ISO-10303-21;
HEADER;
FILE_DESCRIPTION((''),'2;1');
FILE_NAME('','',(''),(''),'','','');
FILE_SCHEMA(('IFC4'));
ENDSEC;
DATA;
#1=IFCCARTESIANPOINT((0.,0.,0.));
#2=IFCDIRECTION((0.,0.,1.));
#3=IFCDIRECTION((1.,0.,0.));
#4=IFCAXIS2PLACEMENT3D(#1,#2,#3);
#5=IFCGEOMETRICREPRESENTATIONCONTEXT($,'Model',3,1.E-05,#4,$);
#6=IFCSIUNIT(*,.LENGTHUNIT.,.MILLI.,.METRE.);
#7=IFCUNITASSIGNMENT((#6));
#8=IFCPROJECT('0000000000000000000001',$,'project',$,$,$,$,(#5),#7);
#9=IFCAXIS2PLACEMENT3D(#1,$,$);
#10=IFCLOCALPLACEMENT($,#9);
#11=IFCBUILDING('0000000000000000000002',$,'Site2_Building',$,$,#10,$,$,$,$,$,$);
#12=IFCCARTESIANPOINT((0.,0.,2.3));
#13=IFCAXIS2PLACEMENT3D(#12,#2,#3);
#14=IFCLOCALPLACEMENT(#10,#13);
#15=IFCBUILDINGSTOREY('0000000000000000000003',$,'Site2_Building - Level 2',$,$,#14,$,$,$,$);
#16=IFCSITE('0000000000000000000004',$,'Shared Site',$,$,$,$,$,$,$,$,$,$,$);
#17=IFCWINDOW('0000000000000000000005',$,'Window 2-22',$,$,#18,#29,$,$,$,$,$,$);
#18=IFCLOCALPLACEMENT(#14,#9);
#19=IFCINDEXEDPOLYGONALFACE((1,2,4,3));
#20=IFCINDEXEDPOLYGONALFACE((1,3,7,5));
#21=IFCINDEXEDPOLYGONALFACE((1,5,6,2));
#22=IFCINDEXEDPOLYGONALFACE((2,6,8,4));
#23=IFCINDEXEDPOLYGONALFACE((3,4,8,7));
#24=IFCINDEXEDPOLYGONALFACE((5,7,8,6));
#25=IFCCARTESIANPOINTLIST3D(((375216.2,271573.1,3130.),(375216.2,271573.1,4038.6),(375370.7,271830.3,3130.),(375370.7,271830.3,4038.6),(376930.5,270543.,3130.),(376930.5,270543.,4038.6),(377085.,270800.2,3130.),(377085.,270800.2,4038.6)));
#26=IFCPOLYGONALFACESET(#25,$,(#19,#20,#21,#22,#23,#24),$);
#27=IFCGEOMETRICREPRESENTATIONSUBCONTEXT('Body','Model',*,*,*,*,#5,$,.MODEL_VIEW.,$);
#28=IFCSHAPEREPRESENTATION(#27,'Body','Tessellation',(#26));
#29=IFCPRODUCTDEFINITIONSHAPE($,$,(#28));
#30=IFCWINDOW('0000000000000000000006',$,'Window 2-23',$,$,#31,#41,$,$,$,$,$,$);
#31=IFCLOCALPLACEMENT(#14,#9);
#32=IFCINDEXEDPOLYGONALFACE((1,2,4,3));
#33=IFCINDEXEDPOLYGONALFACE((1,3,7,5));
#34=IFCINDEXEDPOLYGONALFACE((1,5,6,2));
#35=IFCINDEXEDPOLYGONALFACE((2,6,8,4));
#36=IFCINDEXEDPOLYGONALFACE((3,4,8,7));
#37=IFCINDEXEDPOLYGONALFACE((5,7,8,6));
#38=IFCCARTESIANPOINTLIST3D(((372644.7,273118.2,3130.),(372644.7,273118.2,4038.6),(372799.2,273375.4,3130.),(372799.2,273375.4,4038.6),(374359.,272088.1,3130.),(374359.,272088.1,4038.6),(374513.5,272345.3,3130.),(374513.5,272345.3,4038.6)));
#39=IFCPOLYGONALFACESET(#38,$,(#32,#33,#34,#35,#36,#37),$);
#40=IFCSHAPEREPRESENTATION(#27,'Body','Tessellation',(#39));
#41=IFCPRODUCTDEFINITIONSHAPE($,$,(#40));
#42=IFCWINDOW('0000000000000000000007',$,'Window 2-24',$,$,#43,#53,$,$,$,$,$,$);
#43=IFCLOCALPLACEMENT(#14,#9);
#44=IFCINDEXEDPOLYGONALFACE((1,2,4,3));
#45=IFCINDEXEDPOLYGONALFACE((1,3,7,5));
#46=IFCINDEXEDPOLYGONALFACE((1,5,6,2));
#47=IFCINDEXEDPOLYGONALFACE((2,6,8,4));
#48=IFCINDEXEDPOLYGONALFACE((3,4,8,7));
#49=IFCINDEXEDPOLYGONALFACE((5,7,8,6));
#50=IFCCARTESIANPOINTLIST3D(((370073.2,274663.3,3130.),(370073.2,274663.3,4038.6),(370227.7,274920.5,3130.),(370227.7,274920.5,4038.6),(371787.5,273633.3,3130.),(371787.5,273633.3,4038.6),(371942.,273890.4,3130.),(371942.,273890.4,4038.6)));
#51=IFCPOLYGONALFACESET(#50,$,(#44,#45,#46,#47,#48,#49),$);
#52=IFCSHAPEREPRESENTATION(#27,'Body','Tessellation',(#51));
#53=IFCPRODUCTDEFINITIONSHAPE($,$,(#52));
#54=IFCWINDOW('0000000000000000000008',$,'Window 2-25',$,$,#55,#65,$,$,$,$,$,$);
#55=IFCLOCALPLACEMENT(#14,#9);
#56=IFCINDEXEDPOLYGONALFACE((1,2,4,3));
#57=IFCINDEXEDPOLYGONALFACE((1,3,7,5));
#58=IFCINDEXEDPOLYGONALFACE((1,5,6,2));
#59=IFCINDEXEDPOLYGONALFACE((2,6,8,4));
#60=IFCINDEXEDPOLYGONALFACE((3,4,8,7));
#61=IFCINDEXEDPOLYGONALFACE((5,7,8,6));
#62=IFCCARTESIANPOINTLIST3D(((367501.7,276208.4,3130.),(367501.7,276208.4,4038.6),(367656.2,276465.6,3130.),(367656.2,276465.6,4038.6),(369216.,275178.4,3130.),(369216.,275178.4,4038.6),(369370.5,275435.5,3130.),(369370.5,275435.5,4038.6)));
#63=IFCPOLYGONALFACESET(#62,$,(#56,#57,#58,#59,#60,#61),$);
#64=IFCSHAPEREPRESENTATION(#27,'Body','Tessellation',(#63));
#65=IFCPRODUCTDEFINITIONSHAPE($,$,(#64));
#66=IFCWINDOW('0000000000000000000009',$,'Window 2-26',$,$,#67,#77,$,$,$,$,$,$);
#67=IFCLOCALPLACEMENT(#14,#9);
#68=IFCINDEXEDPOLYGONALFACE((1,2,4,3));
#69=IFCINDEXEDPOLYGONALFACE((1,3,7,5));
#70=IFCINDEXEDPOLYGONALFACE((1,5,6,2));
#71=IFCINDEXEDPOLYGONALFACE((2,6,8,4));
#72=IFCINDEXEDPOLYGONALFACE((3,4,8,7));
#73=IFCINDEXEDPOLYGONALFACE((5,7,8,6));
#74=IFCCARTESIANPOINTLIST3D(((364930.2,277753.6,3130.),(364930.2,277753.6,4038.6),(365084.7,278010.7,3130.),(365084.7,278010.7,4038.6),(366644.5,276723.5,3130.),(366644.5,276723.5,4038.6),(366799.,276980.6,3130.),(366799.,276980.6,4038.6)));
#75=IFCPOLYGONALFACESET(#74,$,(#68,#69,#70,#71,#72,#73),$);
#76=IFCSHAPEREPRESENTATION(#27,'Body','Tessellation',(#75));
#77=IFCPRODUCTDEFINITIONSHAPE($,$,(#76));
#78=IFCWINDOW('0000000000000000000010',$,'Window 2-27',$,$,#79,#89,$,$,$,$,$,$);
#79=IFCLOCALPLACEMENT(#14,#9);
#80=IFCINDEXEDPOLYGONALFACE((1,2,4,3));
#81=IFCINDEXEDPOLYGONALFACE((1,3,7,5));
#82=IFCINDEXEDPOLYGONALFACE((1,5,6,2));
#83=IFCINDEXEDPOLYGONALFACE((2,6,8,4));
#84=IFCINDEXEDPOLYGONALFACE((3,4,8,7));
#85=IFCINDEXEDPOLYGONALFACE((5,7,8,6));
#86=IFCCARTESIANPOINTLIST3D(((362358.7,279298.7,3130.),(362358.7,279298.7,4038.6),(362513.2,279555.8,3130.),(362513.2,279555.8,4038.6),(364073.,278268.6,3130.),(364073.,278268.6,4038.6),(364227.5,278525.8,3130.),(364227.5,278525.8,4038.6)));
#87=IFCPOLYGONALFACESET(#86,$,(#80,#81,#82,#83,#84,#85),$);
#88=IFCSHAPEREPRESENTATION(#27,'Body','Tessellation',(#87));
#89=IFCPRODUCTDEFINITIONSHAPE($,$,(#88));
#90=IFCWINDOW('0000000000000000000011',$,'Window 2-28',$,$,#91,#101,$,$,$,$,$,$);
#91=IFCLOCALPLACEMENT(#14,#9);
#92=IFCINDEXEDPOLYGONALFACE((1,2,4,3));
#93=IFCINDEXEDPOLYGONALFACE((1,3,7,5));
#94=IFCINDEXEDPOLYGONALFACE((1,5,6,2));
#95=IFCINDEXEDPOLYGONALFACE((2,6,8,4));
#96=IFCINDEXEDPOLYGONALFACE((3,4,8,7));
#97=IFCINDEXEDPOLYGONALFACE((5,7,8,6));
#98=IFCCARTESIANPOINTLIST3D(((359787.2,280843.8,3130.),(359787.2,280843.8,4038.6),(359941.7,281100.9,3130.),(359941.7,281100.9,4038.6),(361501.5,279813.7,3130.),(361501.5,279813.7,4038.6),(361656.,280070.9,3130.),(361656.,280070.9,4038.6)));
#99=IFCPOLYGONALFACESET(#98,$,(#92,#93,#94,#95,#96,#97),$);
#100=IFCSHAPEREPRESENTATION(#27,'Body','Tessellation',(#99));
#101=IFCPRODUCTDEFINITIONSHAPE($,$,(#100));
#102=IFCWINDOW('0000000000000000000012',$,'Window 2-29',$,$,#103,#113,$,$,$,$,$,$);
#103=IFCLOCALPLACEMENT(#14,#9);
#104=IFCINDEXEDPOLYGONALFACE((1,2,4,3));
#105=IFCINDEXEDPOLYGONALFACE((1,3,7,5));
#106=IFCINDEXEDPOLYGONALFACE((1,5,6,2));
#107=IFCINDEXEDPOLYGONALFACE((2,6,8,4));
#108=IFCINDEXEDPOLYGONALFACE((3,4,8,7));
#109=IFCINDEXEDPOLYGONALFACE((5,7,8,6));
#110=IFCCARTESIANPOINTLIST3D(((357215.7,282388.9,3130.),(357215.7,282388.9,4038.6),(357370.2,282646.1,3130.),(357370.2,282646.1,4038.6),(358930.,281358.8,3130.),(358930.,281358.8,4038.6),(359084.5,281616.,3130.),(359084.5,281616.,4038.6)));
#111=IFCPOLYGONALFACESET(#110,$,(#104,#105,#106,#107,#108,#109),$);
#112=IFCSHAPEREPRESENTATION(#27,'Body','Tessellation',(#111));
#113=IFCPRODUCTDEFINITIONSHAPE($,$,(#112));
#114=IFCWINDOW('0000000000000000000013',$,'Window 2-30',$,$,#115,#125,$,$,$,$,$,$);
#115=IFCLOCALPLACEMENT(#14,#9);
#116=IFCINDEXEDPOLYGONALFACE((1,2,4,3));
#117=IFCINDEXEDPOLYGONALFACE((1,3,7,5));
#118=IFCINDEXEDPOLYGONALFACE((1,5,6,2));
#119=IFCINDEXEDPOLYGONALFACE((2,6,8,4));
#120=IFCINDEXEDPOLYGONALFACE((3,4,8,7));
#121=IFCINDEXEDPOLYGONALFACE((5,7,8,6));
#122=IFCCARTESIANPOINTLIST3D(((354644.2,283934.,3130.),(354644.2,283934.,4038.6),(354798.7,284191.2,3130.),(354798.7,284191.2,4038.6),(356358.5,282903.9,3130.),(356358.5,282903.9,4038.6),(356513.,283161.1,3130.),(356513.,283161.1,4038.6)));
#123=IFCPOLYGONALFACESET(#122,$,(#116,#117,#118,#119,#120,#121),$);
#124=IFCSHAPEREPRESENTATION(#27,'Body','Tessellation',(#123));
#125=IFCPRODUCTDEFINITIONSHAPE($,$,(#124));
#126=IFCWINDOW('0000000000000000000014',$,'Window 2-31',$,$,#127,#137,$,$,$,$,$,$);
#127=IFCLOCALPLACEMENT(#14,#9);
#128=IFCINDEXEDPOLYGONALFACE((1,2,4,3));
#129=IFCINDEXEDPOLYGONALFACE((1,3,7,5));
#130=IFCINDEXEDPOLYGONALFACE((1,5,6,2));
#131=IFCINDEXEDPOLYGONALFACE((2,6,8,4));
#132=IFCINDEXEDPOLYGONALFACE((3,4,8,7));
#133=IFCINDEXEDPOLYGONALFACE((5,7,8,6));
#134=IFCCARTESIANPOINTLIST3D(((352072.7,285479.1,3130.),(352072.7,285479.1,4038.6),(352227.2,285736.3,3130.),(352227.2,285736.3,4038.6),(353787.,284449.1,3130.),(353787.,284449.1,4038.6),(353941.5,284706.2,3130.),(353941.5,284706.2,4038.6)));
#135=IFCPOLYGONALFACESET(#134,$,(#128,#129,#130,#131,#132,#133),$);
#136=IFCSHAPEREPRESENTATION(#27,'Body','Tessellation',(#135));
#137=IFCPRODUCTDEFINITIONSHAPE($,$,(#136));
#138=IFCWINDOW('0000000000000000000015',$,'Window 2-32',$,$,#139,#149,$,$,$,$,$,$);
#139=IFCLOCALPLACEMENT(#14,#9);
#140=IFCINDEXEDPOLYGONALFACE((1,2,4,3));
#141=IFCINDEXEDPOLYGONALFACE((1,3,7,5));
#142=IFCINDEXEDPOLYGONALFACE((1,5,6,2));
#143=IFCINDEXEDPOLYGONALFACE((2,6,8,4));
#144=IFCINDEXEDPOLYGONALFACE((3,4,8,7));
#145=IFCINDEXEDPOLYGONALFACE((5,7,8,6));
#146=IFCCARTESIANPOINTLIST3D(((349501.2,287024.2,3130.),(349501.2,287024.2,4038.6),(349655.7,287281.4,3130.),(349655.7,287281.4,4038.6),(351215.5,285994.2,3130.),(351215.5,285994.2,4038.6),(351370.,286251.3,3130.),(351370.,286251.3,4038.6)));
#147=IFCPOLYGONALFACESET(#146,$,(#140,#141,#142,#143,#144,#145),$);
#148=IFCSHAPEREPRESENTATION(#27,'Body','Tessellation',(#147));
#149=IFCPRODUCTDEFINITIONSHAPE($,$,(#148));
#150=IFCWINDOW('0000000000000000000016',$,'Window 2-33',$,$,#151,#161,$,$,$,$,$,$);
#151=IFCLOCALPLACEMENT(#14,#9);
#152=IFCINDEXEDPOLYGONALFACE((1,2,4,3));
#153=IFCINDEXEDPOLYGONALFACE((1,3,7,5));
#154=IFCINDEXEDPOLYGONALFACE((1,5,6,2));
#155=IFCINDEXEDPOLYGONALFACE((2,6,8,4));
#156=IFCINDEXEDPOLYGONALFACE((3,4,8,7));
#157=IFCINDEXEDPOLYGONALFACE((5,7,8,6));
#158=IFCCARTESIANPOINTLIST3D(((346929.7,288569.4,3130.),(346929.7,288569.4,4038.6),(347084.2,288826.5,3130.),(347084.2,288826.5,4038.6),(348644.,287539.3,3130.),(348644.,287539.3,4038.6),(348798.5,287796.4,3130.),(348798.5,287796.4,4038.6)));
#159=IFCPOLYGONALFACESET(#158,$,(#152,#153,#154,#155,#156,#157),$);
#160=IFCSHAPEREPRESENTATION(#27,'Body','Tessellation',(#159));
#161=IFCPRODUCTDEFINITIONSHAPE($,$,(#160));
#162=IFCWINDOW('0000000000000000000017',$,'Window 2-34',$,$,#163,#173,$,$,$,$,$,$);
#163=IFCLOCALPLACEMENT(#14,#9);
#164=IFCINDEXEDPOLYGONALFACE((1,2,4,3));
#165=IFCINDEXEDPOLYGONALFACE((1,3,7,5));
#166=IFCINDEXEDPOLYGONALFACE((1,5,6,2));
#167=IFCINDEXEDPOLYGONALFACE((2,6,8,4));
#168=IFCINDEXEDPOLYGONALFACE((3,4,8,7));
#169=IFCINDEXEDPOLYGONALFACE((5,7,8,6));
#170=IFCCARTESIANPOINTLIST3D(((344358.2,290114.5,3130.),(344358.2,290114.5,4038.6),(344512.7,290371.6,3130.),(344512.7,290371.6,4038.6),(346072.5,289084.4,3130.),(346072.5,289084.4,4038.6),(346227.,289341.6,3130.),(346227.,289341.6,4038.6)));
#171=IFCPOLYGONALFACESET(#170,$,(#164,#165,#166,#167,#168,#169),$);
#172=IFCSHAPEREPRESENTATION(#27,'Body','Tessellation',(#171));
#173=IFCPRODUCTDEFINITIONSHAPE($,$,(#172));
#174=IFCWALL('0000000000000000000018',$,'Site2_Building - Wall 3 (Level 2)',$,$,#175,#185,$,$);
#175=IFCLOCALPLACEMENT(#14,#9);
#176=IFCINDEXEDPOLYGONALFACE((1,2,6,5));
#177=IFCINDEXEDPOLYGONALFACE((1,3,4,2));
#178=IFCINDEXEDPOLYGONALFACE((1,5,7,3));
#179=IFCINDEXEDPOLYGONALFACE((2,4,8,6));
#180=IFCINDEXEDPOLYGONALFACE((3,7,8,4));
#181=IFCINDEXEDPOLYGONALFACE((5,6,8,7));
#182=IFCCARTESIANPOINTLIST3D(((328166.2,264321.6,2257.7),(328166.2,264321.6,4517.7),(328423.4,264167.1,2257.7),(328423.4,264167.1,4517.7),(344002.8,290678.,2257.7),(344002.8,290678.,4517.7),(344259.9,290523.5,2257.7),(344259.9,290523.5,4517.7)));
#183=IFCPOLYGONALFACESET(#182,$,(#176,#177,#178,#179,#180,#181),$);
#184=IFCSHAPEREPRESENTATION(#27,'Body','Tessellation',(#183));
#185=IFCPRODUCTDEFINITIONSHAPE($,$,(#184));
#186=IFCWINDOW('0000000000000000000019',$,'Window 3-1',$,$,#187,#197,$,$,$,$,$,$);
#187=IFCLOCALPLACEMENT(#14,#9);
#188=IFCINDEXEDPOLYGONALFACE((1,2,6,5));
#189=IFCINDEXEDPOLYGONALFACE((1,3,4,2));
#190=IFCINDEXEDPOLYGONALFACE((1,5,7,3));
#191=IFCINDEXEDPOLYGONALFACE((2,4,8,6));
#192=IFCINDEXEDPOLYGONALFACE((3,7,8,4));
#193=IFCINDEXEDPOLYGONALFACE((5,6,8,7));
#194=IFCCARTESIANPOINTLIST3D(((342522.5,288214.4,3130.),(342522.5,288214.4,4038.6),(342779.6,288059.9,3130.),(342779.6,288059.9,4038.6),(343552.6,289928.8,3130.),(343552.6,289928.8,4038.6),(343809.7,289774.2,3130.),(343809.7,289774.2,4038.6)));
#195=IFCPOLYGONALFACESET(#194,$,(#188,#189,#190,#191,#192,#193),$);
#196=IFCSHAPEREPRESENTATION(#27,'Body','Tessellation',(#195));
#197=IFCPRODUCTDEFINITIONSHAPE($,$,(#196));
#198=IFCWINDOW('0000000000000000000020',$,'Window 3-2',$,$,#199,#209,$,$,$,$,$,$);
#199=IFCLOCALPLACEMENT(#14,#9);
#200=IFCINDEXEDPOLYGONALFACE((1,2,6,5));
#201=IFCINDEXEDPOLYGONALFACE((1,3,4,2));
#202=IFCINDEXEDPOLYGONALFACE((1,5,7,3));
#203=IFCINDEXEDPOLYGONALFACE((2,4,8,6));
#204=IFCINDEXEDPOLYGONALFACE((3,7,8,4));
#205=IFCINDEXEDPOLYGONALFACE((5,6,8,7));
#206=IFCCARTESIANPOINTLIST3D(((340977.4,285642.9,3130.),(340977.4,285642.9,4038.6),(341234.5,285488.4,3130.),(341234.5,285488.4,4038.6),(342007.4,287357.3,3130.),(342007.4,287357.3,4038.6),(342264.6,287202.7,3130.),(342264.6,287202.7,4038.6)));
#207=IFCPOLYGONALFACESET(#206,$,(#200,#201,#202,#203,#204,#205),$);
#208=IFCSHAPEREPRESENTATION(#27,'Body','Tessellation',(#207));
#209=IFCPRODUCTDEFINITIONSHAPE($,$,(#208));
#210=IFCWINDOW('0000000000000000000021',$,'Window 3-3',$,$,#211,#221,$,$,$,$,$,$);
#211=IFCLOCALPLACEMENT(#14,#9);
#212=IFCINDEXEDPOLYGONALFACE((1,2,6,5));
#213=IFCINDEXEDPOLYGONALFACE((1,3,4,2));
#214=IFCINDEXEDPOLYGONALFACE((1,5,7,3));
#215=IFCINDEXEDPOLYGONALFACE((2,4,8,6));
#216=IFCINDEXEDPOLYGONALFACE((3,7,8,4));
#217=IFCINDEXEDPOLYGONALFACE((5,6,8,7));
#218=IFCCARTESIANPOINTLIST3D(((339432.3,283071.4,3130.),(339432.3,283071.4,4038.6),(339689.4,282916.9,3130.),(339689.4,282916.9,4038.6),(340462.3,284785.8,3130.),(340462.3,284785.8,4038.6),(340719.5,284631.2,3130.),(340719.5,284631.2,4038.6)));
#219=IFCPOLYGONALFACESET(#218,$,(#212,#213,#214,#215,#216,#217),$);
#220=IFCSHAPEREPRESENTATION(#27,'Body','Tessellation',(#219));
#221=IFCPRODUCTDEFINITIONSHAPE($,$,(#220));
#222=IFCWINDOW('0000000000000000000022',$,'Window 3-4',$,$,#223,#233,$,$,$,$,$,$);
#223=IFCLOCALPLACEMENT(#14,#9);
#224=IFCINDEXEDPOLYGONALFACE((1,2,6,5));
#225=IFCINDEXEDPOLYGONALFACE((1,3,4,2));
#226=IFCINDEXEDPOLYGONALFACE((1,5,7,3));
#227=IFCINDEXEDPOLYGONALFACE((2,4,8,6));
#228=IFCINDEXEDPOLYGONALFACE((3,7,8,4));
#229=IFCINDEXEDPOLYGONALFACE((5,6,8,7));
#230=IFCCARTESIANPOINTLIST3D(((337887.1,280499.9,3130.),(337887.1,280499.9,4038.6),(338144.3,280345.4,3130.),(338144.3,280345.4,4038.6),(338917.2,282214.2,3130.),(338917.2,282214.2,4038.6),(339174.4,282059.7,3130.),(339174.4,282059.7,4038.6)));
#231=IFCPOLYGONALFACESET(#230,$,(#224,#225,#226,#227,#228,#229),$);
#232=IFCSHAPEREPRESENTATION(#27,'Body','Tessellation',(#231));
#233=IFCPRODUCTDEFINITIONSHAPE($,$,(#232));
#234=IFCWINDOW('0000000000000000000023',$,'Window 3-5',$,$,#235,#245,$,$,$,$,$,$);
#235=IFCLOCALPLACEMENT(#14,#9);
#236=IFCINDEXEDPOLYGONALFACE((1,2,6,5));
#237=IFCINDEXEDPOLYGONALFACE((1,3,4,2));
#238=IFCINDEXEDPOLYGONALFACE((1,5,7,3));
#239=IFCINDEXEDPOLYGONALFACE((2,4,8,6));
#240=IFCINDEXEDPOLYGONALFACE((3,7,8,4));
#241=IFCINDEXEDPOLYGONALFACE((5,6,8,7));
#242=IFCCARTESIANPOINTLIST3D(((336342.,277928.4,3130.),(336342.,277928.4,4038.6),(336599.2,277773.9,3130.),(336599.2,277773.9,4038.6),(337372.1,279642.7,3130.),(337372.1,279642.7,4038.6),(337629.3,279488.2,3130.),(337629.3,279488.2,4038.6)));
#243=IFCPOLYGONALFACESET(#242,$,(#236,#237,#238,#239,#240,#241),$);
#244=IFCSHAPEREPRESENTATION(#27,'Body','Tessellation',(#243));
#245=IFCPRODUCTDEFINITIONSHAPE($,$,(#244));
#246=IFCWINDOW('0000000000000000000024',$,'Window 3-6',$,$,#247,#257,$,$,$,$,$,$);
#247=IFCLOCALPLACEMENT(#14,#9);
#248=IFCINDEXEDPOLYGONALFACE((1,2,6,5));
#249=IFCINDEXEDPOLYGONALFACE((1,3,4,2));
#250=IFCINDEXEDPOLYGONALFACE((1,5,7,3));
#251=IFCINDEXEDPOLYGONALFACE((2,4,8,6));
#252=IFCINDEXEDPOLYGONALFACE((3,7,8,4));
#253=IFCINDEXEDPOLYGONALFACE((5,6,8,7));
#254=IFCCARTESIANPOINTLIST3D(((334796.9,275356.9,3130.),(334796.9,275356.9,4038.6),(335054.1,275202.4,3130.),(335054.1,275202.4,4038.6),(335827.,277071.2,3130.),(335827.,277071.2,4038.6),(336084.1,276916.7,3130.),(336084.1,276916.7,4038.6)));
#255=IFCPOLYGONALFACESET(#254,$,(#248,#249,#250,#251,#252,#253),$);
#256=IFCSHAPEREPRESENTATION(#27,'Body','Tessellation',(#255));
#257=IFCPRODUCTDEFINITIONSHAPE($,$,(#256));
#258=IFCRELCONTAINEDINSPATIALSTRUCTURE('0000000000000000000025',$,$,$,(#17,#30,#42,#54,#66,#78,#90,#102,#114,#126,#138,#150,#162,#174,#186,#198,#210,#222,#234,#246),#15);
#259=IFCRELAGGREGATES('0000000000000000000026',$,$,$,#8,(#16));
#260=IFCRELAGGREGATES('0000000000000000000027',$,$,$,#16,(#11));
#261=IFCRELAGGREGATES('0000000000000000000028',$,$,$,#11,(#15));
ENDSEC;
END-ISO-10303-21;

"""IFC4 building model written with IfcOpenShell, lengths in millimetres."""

from ifc_helpers import new_model, si_unit, frame, origin, origin_with_axes, place, context, subcontext, project, spatial, indexed_curve, outline, extrude, element, save


model = new_model("IFC4")

# Units and contexts
model_context = context("Model", 3, precision=1e-05, world=origin_with_axes())
body_context = subcontext(model_context, "Body", "Model", "MODEL_VIEW")
ifc_project = project(units=[si_unit("LENGTHUNIT", "METRE", prefix="MILLI")], contexts=[model_context])

# Site, building, storey
site = spatial("IfcSite", under=ifc_project, Name="Shared Site")
building_placement = place(None, origin())
building = spatial("IfcBuilding", under=site, at=building_placement, Name="Site2_Building")
storey_placement = place(building_placement, frame((0.0, 0.0, 2.3), z_axis=(0.0, 0.0, 1.0), x_axis=(1.0, 0.0, 0.0)))
storey = spatial("IfcBuildingStorey", under=building, at=storey_placement, Name="Site2_Building - Level 2")

# Windows
for number, where, z_axis, x_axis, name in (
    (1, (377085.0, 270800.2, 3130.0), (0.0, 0.0, 1.0), (-0.857167, 0.515038, 0.0), "Window 2-22"),
    (2, (374513.5, 272345.3, 3130.0), (0.0, 0.0, 1.0), (-0.857167, 0.515038, 0.0), "Window 2-23"),
    (3, (371942.0, 273890.4, 3130.0), (0.0, 0.0, 1.0), (-0.857167, 0.515038, 0.0), "Window 2-24"),
    (4, (369370.5, 275435.5, 3130.0), (0.0, 0.0, 1.0), (-0.857167, 0.515038, 0.0), "Window 2-25"),
    (5, (366799.0, 276980.6, 3130.0), (0.0, 0.0, 1.0), (-0.857167, 0.515038, 0.0), "Window 2-26"),
    (6, (364227.5, 278525.8, 3130.0), (0.0, 0.0, 1.0), (-0.857167, 0.515038, 0.0), "Window 2-27"),
    (7, (361656.0, 280070.9, 3130.0), (0.0, 0.0, 1.0), (-0.857167, 0.515038, 0.0), "Window 2-28"),
    (8, (359084.5, 281616.0, 3130.0), (0.0, 0.0, 1.0), (-0.857167, 0.515038, 0.0), "Window 2-29"),
    (9, (356513.0, 283161.1, 3130.0), (0.0, 0.0, 1.0), (-0.857167, 0.515038, 0.0), "Window 2-30"),
    (10, (353941.5, 284706.2, 3130.0), (0.0, 0.0, 1.0), (-0.857167, 0.515038, 0.0), "Window 2-31"),
    (11, (351370.0, 286251.3, 3130.0), (0.0, 0.0, 1.0), (-0.857167, 0.515038, 0.0), "Window 2-32"),
    (12, (348798.5, 287796.4, 3130.0), (0.0, 0.0, 1.0), (-0.857167, 0.515038, 0.0), "Window 2-33"),
    (13, (346227.0, 289341.6, 3130.0), (0.0, 0.0, 1.0), (-0.857167, 0.515038, 0.0), "Window 2-34"),
):
    element("IfcWindow", number, at=place(storey_placement, frame(where, z_axis=z_axis, x_axis=x_axis)), inside=storey, Name=name, context=body_context, shape_type="SweptSolid", body=[
        extrude(outline(indexed_curve([(0.0, 0.0), (0.0, 300.0), (2000.0, 300.0), (2000.0, 0.0), (0.0, 0.0)], self_intersect=False)), origin_with_axes(), (0.0, 0.0, 1.0), 908.6),
    ])

# Wall
wall_placement = place(storey_placement, frame((344002.8, 290678.0, 2257.7), z_axis=(0.0, 0.0, 1.0), x_axis=(-0.515038, -0.857167, 0.0)))
element("IfcWall", 14, at=wall_placement, inside=storey, Name="Site2_Building - Wall 3 (Level 2)", context=body_context, shape_type="SweptSolid", body=[
    extrude(outline(indexed_curve([(0.0, 0.0), (0.0, 300.0), (30748.2, 300.0), (30748.2, 0.0), (0.0, 0.0)], self_intersect=False)), origin_with_axes(), (0.0, 0.0, 1.0), 2260.0),
])

# Windows
for number, where, z_axis, x_axis, name in (
    (15, (343552.6, 289928.8, 3130.0), (0.0, 0.0, 1.0), (-0.515038, -0.857167, 0.0), "Window 3-1"),
    (16, (342007.4, 287357.3, 3130.0), (0.0, 0.0, 1.0), (-0.515038, -0.857167, 0.0), "Window 3-2"),
    (17, (340462.3, 284785.8, 3130.0), (0.0, 0.0, 1.0), (-0.515038, -0.857167, 0.0), "Window 3-3"),
    (18, (338917.2, 282214.2, 3130.0), (0.0, 0.0, 1.0), (-0.515038, -0.857167, 0.0), "Window 3-4"),
    (19, (337372.1, 279642.7, 3130.0), (0.0, 0.0, 1.0), (-0.515038, -0.857167, 0.0), "Window 3-5"),
    (20, (335827.0, 277071.2, 3130.0), (0.0, 0.0, 1.0), (-0.515038, -0.857167, 0.0), "Window 3-6"),
):
    element("IfcWindow", number, at=place(storey_placement, frame(where, z_axis=z_axis, x_axis=x_axis)), inside=storey, Name=name, context=body_context, shape_type="SweptSolid", body=[
        extrude(outline(indexed_curve([(0.0, 0.0), (0.0, 300.0), (2000.0, 300.0), (2000.0, 0.0), (0.0, 0.0)], self_intersect=False)), origin_with_axes(), (0.0, 0.0, 1.0), 908.6),
    ])

save(model, "model.ifc")
